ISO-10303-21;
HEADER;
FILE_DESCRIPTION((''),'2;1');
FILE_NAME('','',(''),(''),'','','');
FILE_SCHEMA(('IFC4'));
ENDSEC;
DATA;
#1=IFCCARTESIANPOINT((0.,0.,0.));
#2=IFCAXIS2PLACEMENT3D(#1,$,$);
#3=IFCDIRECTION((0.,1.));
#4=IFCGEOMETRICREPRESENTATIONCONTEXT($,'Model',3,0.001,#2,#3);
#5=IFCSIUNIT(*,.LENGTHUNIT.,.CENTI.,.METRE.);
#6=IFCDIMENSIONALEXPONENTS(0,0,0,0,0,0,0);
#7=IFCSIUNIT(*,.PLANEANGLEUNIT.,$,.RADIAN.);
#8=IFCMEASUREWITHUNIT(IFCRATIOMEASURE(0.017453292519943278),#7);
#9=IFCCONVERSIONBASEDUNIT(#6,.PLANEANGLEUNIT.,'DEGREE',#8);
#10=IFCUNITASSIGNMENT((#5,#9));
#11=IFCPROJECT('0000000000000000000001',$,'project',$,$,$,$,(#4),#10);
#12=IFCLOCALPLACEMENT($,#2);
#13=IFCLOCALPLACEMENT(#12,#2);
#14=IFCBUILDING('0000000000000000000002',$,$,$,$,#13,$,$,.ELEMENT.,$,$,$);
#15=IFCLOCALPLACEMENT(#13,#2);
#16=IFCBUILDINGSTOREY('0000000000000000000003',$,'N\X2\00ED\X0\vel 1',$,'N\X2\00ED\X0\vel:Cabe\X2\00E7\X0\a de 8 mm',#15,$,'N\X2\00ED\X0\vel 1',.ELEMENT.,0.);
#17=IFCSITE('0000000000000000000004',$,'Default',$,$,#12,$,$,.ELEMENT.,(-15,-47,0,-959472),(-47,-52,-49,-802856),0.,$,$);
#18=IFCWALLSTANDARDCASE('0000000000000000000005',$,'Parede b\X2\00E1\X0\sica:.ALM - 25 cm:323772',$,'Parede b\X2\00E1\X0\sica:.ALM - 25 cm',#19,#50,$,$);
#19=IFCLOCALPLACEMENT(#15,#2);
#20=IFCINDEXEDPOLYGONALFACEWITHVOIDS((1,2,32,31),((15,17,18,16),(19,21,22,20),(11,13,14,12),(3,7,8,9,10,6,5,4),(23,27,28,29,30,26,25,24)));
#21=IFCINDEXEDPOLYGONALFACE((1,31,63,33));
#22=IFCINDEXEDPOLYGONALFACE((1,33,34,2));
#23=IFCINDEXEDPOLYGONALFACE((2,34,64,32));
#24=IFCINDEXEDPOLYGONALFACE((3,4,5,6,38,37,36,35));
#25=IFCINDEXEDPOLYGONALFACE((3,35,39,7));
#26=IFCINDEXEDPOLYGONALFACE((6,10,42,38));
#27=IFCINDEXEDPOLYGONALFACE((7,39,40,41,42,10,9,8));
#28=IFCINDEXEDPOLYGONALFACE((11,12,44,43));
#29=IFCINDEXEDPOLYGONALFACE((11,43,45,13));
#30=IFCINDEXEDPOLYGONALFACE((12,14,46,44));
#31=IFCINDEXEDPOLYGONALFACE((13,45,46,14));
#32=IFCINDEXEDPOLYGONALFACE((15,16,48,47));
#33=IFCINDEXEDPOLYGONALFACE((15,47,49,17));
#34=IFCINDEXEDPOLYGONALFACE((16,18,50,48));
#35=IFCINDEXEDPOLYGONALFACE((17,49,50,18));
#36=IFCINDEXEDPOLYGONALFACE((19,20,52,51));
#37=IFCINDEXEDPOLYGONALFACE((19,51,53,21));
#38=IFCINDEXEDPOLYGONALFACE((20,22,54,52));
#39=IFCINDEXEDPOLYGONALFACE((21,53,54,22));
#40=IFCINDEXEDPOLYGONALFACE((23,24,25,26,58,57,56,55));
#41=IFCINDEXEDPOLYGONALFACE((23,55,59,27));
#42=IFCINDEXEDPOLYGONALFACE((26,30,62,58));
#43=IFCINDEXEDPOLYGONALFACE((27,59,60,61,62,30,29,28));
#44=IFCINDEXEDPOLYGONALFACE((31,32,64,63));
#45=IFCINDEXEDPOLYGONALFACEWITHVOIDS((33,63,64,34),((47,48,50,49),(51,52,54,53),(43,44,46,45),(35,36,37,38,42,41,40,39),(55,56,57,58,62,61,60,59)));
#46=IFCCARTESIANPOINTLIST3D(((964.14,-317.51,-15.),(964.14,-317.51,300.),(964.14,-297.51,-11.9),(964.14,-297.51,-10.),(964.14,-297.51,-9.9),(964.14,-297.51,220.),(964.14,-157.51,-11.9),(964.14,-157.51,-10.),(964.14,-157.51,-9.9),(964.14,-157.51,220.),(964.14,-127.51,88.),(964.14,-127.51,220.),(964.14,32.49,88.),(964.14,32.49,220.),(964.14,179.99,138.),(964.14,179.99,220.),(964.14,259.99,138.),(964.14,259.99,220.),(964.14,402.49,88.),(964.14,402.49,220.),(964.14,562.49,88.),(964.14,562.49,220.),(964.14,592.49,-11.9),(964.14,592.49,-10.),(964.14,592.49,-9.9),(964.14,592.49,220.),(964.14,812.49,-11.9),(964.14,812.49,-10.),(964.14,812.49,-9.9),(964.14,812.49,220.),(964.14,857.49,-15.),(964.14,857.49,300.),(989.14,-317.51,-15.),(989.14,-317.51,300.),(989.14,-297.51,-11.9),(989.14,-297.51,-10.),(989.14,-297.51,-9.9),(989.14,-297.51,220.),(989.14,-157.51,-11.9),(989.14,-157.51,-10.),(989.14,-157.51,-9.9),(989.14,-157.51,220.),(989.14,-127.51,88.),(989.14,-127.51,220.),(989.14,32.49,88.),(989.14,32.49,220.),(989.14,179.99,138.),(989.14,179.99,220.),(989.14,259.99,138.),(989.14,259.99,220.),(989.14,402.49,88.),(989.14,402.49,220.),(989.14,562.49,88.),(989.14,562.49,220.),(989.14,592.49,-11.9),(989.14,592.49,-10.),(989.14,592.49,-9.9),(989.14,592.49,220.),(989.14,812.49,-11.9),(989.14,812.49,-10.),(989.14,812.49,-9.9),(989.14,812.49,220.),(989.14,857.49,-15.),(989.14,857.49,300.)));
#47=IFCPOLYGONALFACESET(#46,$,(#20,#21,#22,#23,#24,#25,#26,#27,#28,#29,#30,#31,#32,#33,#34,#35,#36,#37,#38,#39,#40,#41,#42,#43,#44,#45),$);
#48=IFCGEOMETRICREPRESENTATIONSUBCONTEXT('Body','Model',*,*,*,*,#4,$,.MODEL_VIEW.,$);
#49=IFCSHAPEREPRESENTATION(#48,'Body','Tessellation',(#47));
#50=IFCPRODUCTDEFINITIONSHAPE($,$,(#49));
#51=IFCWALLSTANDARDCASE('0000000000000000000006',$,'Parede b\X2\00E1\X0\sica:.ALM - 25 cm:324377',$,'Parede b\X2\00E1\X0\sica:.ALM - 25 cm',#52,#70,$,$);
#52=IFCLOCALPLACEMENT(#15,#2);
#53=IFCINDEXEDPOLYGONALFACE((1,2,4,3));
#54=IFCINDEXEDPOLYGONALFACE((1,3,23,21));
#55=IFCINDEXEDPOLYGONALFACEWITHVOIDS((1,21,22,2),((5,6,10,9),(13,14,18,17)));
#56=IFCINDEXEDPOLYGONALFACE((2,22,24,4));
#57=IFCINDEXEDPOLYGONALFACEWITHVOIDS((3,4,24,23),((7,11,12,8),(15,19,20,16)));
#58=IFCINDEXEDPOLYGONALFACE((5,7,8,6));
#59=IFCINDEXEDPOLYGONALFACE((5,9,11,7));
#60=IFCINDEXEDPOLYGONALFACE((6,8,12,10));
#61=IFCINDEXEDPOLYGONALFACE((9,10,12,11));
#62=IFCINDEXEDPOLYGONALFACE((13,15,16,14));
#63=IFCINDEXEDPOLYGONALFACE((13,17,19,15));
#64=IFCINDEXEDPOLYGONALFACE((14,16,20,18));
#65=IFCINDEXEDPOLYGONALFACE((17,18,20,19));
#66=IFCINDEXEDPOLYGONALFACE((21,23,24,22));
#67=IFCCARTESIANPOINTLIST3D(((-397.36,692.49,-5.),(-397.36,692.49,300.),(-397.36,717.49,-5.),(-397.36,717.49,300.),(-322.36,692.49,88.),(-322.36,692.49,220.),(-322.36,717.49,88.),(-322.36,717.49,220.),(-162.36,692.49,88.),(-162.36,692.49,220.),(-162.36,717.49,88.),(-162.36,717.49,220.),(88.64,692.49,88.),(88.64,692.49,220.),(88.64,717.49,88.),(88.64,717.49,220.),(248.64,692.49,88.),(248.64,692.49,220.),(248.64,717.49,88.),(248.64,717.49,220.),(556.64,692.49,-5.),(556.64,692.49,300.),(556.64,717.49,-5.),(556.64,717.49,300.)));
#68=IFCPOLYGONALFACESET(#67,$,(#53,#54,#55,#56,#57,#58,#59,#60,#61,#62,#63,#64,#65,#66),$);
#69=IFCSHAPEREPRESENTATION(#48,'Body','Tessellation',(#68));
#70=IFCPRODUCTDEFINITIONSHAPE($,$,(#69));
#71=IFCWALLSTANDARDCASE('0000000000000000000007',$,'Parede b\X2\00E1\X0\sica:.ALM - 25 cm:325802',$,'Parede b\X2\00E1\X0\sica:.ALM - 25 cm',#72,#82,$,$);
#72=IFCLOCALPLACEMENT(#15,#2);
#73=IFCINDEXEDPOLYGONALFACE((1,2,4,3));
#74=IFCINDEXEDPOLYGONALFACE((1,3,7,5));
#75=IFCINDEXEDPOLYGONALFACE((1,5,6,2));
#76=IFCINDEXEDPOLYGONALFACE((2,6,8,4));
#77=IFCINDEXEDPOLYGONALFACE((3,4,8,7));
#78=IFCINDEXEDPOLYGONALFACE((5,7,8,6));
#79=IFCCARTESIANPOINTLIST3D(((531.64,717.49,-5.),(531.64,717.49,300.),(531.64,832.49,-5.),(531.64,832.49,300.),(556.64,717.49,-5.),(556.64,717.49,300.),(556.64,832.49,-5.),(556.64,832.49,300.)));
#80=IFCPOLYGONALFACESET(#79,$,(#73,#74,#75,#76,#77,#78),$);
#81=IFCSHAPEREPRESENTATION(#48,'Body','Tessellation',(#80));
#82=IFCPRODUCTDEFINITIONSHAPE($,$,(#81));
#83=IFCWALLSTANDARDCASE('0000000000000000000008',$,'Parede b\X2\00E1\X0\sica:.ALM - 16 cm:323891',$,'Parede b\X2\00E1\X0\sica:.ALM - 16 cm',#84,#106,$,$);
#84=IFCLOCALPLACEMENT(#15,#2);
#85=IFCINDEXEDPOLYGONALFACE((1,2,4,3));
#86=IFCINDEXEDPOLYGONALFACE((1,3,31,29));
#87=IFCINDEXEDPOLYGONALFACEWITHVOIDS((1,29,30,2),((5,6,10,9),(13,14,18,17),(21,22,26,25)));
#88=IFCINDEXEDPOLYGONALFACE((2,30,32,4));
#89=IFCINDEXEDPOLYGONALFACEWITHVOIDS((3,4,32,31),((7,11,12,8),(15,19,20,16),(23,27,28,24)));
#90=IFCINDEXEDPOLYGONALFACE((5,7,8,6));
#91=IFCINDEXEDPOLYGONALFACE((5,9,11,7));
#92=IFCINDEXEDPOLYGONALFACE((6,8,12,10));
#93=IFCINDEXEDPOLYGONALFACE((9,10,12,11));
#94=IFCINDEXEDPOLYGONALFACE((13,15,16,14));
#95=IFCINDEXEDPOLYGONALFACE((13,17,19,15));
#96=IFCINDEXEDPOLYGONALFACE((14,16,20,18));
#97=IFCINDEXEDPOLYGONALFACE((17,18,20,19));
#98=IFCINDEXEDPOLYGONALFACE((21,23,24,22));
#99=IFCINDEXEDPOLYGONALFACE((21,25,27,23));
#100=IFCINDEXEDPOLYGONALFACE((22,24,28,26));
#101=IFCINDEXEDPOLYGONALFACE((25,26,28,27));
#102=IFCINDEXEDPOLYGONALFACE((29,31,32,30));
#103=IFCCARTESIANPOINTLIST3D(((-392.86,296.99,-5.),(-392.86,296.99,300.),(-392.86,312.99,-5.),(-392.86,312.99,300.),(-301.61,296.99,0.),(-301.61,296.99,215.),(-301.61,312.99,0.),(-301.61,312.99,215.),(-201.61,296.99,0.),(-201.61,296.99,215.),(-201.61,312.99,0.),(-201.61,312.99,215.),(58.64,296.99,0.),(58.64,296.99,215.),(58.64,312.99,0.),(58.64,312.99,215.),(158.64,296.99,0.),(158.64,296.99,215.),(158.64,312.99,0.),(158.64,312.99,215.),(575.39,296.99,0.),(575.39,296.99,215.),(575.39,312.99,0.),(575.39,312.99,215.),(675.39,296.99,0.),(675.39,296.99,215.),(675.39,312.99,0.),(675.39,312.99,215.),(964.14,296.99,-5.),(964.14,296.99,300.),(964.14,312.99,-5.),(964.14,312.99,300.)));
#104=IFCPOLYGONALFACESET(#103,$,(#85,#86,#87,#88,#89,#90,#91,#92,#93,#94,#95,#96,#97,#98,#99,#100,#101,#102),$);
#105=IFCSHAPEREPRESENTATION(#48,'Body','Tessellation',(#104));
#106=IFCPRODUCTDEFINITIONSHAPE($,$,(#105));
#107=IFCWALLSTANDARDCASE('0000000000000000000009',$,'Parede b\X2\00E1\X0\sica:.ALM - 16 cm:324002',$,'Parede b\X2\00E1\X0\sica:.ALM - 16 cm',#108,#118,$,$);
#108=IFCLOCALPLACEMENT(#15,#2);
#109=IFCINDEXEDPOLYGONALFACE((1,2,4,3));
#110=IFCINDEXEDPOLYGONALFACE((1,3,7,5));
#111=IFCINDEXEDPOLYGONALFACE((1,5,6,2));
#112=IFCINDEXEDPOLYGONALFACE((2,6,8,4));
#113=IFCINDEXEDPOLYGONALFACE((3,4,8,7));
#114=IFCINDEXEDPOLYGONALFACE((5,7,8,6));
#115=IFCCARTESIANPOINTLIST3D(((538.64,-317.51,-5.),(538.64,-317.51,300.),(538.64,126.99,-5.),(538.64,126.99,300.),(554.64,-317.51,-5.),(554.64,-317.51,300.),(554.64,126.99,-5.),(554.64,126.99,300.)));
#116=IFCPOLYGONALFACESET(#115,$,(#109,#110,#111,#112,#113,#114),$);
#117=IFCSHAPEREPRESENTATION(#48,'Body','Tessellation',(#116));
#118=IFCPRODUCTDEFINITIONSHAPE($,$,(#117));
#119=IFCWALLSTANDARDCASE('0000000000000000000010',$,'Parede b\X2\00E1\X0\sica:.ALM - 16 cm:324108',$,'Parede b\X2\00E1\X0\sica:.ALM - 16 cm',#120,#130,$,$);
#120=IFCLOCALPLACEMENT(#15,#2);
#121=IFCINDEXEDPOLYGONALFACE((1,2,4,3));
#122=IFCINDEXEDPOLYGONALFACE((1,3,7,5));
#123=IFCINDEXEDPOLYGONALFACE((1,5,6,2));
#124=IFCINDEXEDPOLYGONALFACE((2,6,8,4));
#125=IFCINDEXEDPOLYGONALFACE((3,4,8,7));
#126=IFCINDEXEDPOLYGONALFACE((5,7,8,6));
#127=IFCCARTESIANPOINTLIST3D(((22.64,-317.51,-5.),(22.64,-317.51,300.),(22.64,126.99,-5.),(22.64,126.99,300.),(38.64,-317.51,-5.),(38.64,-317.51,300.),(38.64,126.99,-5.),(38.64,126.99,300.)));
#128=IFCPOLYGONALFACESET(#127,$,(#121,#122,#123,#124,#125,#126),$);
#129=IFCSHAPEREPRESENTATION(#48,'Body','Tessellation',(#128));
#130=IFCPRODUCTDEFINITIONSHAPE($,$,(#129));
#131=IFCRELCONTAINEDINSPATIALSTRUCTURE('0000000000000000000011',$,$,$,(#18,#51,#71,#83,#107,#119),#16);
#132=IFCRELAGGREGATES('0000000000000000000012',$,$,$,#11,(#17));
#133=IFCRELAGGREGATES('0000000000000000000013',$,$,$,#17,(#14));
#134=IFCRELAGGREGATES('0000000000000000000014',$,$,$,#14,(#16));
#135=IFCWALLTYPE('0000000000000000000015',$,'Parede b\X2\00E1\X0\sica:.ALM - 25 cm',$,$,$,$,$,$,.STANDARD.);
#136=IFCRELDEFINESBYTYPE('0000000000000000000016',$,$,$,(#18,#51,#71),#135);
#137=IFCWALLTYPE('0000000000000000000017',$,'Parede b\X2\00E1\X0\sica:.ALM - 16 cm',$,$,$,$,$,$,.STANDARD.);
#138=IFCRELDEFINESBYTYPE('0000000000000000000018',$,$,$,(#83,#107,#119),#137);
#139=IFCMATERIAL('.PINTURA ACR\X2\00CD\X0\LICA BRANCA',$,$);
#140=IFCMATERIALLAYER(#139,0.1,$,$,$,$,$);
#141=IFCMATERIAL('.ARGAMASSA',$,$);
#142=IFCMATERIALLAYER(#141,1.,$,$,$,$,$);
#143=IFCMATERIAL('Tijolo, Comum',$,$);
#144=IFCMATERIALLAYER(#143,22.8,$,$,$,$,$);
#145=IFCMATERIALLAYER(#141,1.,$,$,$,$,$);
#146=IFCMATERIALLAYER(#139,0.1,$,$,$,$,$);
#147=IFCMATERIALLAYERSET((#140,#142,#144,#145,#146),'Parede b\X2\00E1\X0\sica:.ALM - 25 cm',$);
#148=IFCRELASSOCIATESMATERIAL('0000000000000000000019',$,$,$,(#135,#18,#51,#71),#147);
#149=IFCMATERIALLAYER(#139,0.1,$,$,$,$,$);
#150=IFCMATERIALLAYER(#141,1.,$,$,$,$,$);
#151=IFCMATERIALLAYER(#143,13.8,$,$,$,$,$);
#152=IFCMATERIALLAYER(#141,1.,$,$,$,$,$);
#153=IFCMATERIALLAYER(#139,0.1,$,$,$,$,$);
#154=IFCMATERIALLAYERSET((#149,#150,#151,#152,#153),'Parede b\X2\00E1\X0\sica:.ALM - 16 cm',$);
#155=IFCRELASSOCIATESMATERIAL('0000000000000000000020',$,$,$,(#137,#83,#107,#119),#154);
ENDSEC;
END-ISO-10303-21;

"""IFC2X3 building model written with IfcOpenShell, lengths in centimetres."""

from ifc_helpers import new_model, entity, si_unit, converted_unit, direction, frame, frame_2d, origin, origin_2d_with_axis, place, context, subcontext, project, spatial, rectangle, extrude, material, layer, layer_set, layer_usage, type_object, element, save


model = new_model("IFC2X3")

# Units and contexts
model_context = context("Model", 3, precision=0.001, world=origin(), true_north=direction((0.0, 1.0)))
body_context = subcontext(model_context, "Body", "Model", "MODEL_VIEW")
ifc_project = project(units=[si_unit("LENGTHUNIT", "METRE", prefix="CENTI"), converted_unit("PLANEANGLEUNIT", "DEGREE", entity("IfcRatioMeasure", 0.017453292519943278), si_unit("PLANEANGLEUNIT", "RADIAN"), dimensions=[0, 0, 0, 0, 0, 0, 0])], contexts=[model_context])

# Site, building, storey
site_placement = place(None, origin())
site = spatial("IfcSite", under=ifc_project, at=site_placement, Name="Default", CompositionType="ELEMENT", RefLatitude=(-15, -47, 0, -959472), RefLongitude=(-47, -52, -49, -802856), RefElevation=0.0)
building_placement = place(site_placement, origin())
building = spatial("IfcBuilding", under=site, at=building_placement, CompositionType="ELEMENT")
storey_placement = place(building_placement, origin())
storey = spatial("IfcBuildingStorey", under=building, at=storey_placement, Name="Nível 1", ObjectType="Nível:Cabeça de 8 mm", LongName="Nível 1", CompositionType="ELEMENT", Elevation=0.0)

# Walls, openings
ifc_material_1 = material(Name=".PINTURA ACRÍLICA BRANCA")
ifc_layer_1 = layer(ifc_material_1, 0.1)
ifc_material_2 = material(Name=".ARGAMASSA")
ifc_layer_2 = layer(ifc_material_2, 1.0)
ifc_material_3 = material(Name="Tijolo, Comum")
ifc_layer_3 = layer(ifc_material_3, 22.8)
ifc_layer_4 = layer(ifc_material_2, 1.0)
ifc_layer_5 = layer(ifc_material_1, 0.1)
ifc_layer_set_1 = layer_set([ifc_layer_1, ifc_layer_2, ifc_layer_3, ifc_layer_4, ifc_layer_5], Name="Parede básica:.ALM - 25 cm")
ifc_layer_usage_1 = layer_usage(ifc_layer_set_1, "AXIS2", "NEGATIVE", 12.5)
wall_type_1 = type_object("IfcWallType", Name="Parede básica:.ALM - 25 cm", PredefinedType="STANDARD", material=ifc_layer_set_1)
wall_1_placement = place(storey_placement, frame((976.64, -317.51, -15.0), z_axis=(0.0, 0.0, 1.0), x_axis=(0.0, 1.0, 0.0)))
wall_1 = element("IfcWallStandardCase", 1, at=wall_1_placement, inside=storey, type_object=wall_type_1, material=ifc_layer_usage_1, Name="Parede básica:.ALM - 25 cm:323772", ObjectType="Parede básica:.ALM - 25 cm", context=body_context, shape_type="SweptSolid", body=[
    extrude(rectangle(XDim=1175.0, YDim=25.0, at=frame_2d((587.5, 0.0), x_axis=(-1.0, 0.0))), origin(), (0.0, 0.0, 1.0), 315.0),
])
opening_1_placement = place(wall_1_placement, frame((317.51, 976.64, 15.0), z_axis=(0.0, 0.0, 1.0), x_axis=(0.0, -1.0, 0.0)))
element("IfcOpeningElement", 2, at=opening_1_placement, cuts=wall_1, ObjectType="Opening", context=body_context, shape_type="SweptSolid", body=[
    extrude(rectangle(XDim=230.0, YDim=140.0, at=frame_2d((0.0, 0.0), x_axis=(1.0, 0.0))), frame((1116.54, -227.51, 105.0), z_axis=(-1.0, 0.0, 0.0), x_axis=(0.0, 0.0, 1.0)), (0.0, 0.0, 1.0), 304.8),
])
opening_2_placement = place(wall_1_placement, frame((317.51, 976.64, 15.0), z_axis=(0.0, 0.0, 1.0), x_axis=(0.0, -1.0, 0.0)))
element("IfcOpeningElement", 3, at=opening_2_placement, cuts=wall_1, ObjectType="Opening", context=body_context, shape_type="SweptSolid", body=[
    extrude(rectangle(XDim=2.0, YDim=140.0, at=origin_2d_with_axis()), frame((1116.54, -227.51, -10.9), z_axis=(-1.0, 0.0, 0.0), x_axis=(0.0, 0.0, 1.0)), (0.0, 0.0, 1.0), 304.8),
])
opening_3_placement = place(wall_1_placement, frame((317.51, 976.64, 15.0), z_axis=(0.0, 0.0, 1.0), x_axis=(0.0, -1.0, 0.0)))
element("IfcOpeningElement", 4, at=opening_3_placement, cuts=wall_1, ObjectType="Opening", context=body_context, shape_type="SweptSolid", body=[
    extrude(rectangle(XDim=230.0, YDim=220.0, at=frame_2d((0.0, 0.0), x_axis=(0.0, 1.0))), frame((1116.54, 702.49, 105.0), z_axis=(-1.0, 0.0, 0.0), x_axis=(0.0, -1.0, 0.0)), (0.0, 0.0, 1.0), 304.8),
])
opening_4_placement = place(wall_1_placement, frame((317.51, 976.64, 15.0), z_axis=(0.0, 0.0, 1.0), x_axis=(0.0, -1.0, 0.0)))
element("IfcOpeningElement", 5, at=opening_4_placement, cuts=wall_1, ObjectType="Opening", context=body_context, shape_type="SweptSolid", body=[
    extrude(rectangle(XDim=2.0, YDim=220.0, at=frame_2d((0.0, 0.0), x_axis=(0.0, 1.0))), frame((1116.54, 702.49, -10.9), z_axis=(-1.0, 0.0, 0.0), x_axis=(0.0, -1.0, 0.0)), (0.0, 0.0, 1.0), 304.8),
])
opening_5_placement = place(wall_1_placement, frame((880.0, 12.5, 103.0)))
element("IfcOpeningElement", 6, at=opening_5_placement, cuts=wall_1, ObjectType="Opening", context=body_context, shape_type="SweptSolid", body=[
    extrude(rectangle(XDim=132.0, YDim=160.0, at=frame_2d((66.0, 80.0), x_axis=(1.0, 0.0))), frame((0.0, 0.0, 0.0), z_axis=(0.0, -1.0, 0.0), x_axis=(0.0, 0.0, 1.0)), (0.0, 0.0, 1.0), 25.0),
])
opening_6_placement = place(wall_1_placement, frame((350.0, 12.5, 103.0)))
element("IfcOpeningElement", 7, at=opening_6_placement, cuts=wall_1, ObjectType="Opening", context=body_context, shape_type="SweptSolid", body=[
    extrude(rectangle(XDim=132.0, YDim=160.0, at=frame_2d((66.0, 80.0), x_axis=(1.0, 0.0))), frame((0.0, 0.0, 0.0), z_axis=(0.0, -1.0, 0.0), x_axis=(0.0, 0.0, 1.0)), (0.0, 0.0, 1.0), 25.0),
])
opening_7_placement = place(wall_1_placement, frame((577.5, 12.5, 153.0)))
element("IfcOpeningElement", 8, at=opening_7_placement, cuts=wall_1, ObjectType="Opening", context=body_context, shape_type="SweptSolid", body=[
    extrude(rectangle(XDim=82.0, YDim=80.0, at=frame_2d((41.0, 40.0), x_axis=(1.0, 0.0))), frame((0.0, 0.0, 0.0), z_axis=(0.0, -1.0, 0.0), x_axis=(0.0, 0.0, 1.0)), (0.0, 0.0, 1.0), 25.0),
])
wall_2_placement = place(storey_placement, frame((556.64, 704.99, -5.0), z_axis=(0.0, 0.0, 1.0), x_axis=(-1.0, 0.0, 0.0)))
wall_2 = element("IfcWallStandardCase", 9, at=wall_2_placement, inside=storey, type_object=wall_type_1, material=ifc_layer_usage_1, Name="Parede básica:.ALM - 25 cm:324377", ObjectType="Parede básica:.ALM - 25 cm", context=body_context, shape_type="SweptSolid", body=[
    extrude(rectangle(XDim=954.0, YDim=25.0, at=frame_2d((477.0, 0.0), x_axis=(1.0, 0.0))), origin(), (0.0, 0.0, 1.0), 305.0),
])
opening_8_placement = place(wall_2_placement, frame((879.0, 12.5, 93.0)))
element("IfcOpeningElement", 10, at=opening_8_placement, cuts=wall_2, ObjectType="Opening", context=body_context, shape_type="SweptSolid", body=[
    extrude(rectangle(XDim=132.0, YDim=160.0, at=frame_2d((66.0, 80.0), x_axis=(1.0, 0.0))), frame((0.0, 0.0, 0.0), z_axis=(0.0, -1.0, 0.0), x_axis=(0.0, 0.0, 1.0)), (0.0, 0.0, 1.0), 25.0),
])
opening_9_placement = place(wall_2_placement, frame((468.0, 12.5, 93.0)))
element("IfcOpeningElement", 11, at=opening_9_placement, cuts=wall_2, ObjectType="Opening", context=body_context, shape_type="SweptSolid", body=[
    extrude(rectangle(XDim=132.0, YDim=160.0, at=frame_2d((66.0, 80.0), x_axis=(1.0, 0.0))), frame((0.0, 0.0, 0.0), z_axis=(0.0, -1.0, 0.0), x_axis=(0.0, 0.0, 1.0)), (0.0, 0.0, 1.0), 25.0),
])

# Wall
ifc_layer_usage_2 = layer_usage(ifc_layer_set_1, "AXIS2", "POSITIVE", -12.5)
wall_3_placement = place(storey_placement, frame((544.14, 717.49, -5.0), z_axis=(0.0, 0.0, 1.0), x_axis=(0.0, 1.0, 0.0)))
element("IfcWallStandardCase", 12, at=wall_3_placement, inside=storey, type_object=wall_type_1, material=ifc_layer_usage_2, Name="Parede básica:.ALM - 25 cm:325802", ObjectType="Parede básica:.ALM - 25 cm", context=body_context, shape_type="SweptSolid", body=[
    extrude(rectangle(XDim=115.0, YDim=25.0, at=frame_2d((57.5, 0.0), x_axis=(-1.0, 0.0))), origin(), (0.0, 0.0, 1.0), 305.0),
])

# Wall, openings
ifc_layer_6 = layer(ifc_material_1, 0.1)
ifc_layer_7 = layer(ifc_material_2, 1.0)
ifc_layer_8 = layer(ifc_material_3, 13.8)
ifc_layer_9 = layer(ifc_material_2, 1.0)
ifc_layer_10 = layer(ifc_material_1, 0.1)
ifc_layer_set_2 = layer_set([ifc_layer_6, ifc_layer_7, ifc_layer_8, ifc_layer_9, ifc_layer_10], Name="Parede básica:.ALM - 16 cm")
ifc_layer_usage_3 = layer_usage(ifc_layer_set_2, "AXIS2", "NEGATIVE", 8.0)
wall_type_2 = type_object("IfcWallType", Name="Parede básica:.ALM - 16 cm", PredefinedType="STANDARD", material=ifc_layer_set_2)
wall_4_placement = place(storey_placement, frame((964.14, 304.99, -5.0), z_axis=(0.0, 0.0, 1.0), x_axis=(-1.0, 0.0, 0.0)))
wall_4 = element("IfcWallStandardCase", 13, at=wall_4_placement, inside=storey, type_object=wall_type_2, material=ifc_layer_usage_3, Name="Parede básica:.ALM - 16 cm:323891", ObjectType="Parede básica:.ALM - 16 cm", context=body_context, shape_type="SweptSolid", body=[
    extrude(rectangle(XDim=1357.0, YDim=16.0, at=frame_2d((678.5, 0.0), x_axis=(-1.0, 0.0))), origin(), (0.0, 0.0, 1.0), 305.0),
])
opening_10_placement = place(wall_4_placement, frame((1265.75, 8.0, 5.0)))
element("IfcOpeningElement", 14, at=opening_10_placement, cuts=wall_4, ObjectType="Opening", context=body_context, shape_type="SweptSolid", body=[
    extrude(rectangle(XDim=215.0, YDim=100.0, at=frame_2d((107.5, 50.0), x_axis=(1.0, 0.0))), frame((0.0, 0.0, 0.0), z_axis=(0.0, -1.0, 0.0), x_axis=(0.0, 0.0, 1.0)), (0.0, 0.0, 1.0), 16.0),
])
opening_11_placement = place(wall_4_placement, frame((905.5, 8.0, 5.0)))
element("IfcOpeningElement", 15, at=opening_11_placement, cuts=wall_4, ObjectType="Opening", context=body_context, shape_type="SweptSolid", body=[
    extrude(rectangle(XDim=215.0, YDim=100.0, at=frame_2d((107.5, 50.0), x_axis=(1.0, 0.0))), frame((0.0, 0.0, 0.0), z_axis=(0.0, -1.0, 0.0), x_axis=(0.0, 0.0, 1.0)), (0.0, 0.0, 1.0), 16.0),
])
opening_12_placement = place(wall_4_placement, frame((388.75, 8.0, 5.0)))
element("IfcOpeningElement", 16, at=opening_12_placement, cuts=wall_4, ObjectType="Opening", context=body_context, shape_type="SweptSolid", body=[
    extrude(rectangle(XDim=215.0, YDim=100.0, at=frame_2d((107.5, 50.0), x_axis=(1.0, 0.0))), frame((0.0, 0.0, 0.0), z_axis=(0.0, -1.0, 0.0), x_axis=(0.0, 0.0, 1.0)), (0.0, 0.0, 1.0), 16.0),
])

# Walls
wall_5_placement = place(storey_placement, frame((546.64, -317.51, -5.0), z_axis=(0.0, 0.0, 1.0), x_axis=(0.0, 1.0, 0.0)))
element("IfcWallStandardCase", 17, at=wall_5_placement, inside=storey, type_object=wall_type_2, material=ifc_layer_usage_3, Name="Parede básica:.ALM - 16 cm:324002", ObjectType="Parede básica:.ALM - 16 cm", context=body_context, shape_type="SweptSolid", body=[
    extrude(rectangle(XDim=444.5, YDim=16.0, at=frame_2d((222.25, 0.0), x_axis=(-1.0, 0.0))), origin(), (0.0, 0.0, 1.0), 305.0),
])
wall_6_placement = place(storey_placement, frame((30.64, -317.51, -5.0), z_axis=(0.0, 0.0, 1.0), x_axis=(0.0, 1.0, 0.0)))
element("IfcWallStandardCase", 18, at=wall_6_placement, inside=storey, type_object=wall_type_2, material=ifc_layer_usage_3, Name="Parede básica:.ALM - 16 cm:324108", ObjectType="Parede básica:.ALM - 16 cm", context=body_context, shape_type="SweptSolid", body=[
    extrude(rectangle(XDim=444.5, YDim=16.0, at=frame_2d((222.25, 0.0), x_axis=(-1.0, 0.0))), origin(), (0.0, 0.0, 1.0), 305.0),
])

save(model, "model.ifc")
